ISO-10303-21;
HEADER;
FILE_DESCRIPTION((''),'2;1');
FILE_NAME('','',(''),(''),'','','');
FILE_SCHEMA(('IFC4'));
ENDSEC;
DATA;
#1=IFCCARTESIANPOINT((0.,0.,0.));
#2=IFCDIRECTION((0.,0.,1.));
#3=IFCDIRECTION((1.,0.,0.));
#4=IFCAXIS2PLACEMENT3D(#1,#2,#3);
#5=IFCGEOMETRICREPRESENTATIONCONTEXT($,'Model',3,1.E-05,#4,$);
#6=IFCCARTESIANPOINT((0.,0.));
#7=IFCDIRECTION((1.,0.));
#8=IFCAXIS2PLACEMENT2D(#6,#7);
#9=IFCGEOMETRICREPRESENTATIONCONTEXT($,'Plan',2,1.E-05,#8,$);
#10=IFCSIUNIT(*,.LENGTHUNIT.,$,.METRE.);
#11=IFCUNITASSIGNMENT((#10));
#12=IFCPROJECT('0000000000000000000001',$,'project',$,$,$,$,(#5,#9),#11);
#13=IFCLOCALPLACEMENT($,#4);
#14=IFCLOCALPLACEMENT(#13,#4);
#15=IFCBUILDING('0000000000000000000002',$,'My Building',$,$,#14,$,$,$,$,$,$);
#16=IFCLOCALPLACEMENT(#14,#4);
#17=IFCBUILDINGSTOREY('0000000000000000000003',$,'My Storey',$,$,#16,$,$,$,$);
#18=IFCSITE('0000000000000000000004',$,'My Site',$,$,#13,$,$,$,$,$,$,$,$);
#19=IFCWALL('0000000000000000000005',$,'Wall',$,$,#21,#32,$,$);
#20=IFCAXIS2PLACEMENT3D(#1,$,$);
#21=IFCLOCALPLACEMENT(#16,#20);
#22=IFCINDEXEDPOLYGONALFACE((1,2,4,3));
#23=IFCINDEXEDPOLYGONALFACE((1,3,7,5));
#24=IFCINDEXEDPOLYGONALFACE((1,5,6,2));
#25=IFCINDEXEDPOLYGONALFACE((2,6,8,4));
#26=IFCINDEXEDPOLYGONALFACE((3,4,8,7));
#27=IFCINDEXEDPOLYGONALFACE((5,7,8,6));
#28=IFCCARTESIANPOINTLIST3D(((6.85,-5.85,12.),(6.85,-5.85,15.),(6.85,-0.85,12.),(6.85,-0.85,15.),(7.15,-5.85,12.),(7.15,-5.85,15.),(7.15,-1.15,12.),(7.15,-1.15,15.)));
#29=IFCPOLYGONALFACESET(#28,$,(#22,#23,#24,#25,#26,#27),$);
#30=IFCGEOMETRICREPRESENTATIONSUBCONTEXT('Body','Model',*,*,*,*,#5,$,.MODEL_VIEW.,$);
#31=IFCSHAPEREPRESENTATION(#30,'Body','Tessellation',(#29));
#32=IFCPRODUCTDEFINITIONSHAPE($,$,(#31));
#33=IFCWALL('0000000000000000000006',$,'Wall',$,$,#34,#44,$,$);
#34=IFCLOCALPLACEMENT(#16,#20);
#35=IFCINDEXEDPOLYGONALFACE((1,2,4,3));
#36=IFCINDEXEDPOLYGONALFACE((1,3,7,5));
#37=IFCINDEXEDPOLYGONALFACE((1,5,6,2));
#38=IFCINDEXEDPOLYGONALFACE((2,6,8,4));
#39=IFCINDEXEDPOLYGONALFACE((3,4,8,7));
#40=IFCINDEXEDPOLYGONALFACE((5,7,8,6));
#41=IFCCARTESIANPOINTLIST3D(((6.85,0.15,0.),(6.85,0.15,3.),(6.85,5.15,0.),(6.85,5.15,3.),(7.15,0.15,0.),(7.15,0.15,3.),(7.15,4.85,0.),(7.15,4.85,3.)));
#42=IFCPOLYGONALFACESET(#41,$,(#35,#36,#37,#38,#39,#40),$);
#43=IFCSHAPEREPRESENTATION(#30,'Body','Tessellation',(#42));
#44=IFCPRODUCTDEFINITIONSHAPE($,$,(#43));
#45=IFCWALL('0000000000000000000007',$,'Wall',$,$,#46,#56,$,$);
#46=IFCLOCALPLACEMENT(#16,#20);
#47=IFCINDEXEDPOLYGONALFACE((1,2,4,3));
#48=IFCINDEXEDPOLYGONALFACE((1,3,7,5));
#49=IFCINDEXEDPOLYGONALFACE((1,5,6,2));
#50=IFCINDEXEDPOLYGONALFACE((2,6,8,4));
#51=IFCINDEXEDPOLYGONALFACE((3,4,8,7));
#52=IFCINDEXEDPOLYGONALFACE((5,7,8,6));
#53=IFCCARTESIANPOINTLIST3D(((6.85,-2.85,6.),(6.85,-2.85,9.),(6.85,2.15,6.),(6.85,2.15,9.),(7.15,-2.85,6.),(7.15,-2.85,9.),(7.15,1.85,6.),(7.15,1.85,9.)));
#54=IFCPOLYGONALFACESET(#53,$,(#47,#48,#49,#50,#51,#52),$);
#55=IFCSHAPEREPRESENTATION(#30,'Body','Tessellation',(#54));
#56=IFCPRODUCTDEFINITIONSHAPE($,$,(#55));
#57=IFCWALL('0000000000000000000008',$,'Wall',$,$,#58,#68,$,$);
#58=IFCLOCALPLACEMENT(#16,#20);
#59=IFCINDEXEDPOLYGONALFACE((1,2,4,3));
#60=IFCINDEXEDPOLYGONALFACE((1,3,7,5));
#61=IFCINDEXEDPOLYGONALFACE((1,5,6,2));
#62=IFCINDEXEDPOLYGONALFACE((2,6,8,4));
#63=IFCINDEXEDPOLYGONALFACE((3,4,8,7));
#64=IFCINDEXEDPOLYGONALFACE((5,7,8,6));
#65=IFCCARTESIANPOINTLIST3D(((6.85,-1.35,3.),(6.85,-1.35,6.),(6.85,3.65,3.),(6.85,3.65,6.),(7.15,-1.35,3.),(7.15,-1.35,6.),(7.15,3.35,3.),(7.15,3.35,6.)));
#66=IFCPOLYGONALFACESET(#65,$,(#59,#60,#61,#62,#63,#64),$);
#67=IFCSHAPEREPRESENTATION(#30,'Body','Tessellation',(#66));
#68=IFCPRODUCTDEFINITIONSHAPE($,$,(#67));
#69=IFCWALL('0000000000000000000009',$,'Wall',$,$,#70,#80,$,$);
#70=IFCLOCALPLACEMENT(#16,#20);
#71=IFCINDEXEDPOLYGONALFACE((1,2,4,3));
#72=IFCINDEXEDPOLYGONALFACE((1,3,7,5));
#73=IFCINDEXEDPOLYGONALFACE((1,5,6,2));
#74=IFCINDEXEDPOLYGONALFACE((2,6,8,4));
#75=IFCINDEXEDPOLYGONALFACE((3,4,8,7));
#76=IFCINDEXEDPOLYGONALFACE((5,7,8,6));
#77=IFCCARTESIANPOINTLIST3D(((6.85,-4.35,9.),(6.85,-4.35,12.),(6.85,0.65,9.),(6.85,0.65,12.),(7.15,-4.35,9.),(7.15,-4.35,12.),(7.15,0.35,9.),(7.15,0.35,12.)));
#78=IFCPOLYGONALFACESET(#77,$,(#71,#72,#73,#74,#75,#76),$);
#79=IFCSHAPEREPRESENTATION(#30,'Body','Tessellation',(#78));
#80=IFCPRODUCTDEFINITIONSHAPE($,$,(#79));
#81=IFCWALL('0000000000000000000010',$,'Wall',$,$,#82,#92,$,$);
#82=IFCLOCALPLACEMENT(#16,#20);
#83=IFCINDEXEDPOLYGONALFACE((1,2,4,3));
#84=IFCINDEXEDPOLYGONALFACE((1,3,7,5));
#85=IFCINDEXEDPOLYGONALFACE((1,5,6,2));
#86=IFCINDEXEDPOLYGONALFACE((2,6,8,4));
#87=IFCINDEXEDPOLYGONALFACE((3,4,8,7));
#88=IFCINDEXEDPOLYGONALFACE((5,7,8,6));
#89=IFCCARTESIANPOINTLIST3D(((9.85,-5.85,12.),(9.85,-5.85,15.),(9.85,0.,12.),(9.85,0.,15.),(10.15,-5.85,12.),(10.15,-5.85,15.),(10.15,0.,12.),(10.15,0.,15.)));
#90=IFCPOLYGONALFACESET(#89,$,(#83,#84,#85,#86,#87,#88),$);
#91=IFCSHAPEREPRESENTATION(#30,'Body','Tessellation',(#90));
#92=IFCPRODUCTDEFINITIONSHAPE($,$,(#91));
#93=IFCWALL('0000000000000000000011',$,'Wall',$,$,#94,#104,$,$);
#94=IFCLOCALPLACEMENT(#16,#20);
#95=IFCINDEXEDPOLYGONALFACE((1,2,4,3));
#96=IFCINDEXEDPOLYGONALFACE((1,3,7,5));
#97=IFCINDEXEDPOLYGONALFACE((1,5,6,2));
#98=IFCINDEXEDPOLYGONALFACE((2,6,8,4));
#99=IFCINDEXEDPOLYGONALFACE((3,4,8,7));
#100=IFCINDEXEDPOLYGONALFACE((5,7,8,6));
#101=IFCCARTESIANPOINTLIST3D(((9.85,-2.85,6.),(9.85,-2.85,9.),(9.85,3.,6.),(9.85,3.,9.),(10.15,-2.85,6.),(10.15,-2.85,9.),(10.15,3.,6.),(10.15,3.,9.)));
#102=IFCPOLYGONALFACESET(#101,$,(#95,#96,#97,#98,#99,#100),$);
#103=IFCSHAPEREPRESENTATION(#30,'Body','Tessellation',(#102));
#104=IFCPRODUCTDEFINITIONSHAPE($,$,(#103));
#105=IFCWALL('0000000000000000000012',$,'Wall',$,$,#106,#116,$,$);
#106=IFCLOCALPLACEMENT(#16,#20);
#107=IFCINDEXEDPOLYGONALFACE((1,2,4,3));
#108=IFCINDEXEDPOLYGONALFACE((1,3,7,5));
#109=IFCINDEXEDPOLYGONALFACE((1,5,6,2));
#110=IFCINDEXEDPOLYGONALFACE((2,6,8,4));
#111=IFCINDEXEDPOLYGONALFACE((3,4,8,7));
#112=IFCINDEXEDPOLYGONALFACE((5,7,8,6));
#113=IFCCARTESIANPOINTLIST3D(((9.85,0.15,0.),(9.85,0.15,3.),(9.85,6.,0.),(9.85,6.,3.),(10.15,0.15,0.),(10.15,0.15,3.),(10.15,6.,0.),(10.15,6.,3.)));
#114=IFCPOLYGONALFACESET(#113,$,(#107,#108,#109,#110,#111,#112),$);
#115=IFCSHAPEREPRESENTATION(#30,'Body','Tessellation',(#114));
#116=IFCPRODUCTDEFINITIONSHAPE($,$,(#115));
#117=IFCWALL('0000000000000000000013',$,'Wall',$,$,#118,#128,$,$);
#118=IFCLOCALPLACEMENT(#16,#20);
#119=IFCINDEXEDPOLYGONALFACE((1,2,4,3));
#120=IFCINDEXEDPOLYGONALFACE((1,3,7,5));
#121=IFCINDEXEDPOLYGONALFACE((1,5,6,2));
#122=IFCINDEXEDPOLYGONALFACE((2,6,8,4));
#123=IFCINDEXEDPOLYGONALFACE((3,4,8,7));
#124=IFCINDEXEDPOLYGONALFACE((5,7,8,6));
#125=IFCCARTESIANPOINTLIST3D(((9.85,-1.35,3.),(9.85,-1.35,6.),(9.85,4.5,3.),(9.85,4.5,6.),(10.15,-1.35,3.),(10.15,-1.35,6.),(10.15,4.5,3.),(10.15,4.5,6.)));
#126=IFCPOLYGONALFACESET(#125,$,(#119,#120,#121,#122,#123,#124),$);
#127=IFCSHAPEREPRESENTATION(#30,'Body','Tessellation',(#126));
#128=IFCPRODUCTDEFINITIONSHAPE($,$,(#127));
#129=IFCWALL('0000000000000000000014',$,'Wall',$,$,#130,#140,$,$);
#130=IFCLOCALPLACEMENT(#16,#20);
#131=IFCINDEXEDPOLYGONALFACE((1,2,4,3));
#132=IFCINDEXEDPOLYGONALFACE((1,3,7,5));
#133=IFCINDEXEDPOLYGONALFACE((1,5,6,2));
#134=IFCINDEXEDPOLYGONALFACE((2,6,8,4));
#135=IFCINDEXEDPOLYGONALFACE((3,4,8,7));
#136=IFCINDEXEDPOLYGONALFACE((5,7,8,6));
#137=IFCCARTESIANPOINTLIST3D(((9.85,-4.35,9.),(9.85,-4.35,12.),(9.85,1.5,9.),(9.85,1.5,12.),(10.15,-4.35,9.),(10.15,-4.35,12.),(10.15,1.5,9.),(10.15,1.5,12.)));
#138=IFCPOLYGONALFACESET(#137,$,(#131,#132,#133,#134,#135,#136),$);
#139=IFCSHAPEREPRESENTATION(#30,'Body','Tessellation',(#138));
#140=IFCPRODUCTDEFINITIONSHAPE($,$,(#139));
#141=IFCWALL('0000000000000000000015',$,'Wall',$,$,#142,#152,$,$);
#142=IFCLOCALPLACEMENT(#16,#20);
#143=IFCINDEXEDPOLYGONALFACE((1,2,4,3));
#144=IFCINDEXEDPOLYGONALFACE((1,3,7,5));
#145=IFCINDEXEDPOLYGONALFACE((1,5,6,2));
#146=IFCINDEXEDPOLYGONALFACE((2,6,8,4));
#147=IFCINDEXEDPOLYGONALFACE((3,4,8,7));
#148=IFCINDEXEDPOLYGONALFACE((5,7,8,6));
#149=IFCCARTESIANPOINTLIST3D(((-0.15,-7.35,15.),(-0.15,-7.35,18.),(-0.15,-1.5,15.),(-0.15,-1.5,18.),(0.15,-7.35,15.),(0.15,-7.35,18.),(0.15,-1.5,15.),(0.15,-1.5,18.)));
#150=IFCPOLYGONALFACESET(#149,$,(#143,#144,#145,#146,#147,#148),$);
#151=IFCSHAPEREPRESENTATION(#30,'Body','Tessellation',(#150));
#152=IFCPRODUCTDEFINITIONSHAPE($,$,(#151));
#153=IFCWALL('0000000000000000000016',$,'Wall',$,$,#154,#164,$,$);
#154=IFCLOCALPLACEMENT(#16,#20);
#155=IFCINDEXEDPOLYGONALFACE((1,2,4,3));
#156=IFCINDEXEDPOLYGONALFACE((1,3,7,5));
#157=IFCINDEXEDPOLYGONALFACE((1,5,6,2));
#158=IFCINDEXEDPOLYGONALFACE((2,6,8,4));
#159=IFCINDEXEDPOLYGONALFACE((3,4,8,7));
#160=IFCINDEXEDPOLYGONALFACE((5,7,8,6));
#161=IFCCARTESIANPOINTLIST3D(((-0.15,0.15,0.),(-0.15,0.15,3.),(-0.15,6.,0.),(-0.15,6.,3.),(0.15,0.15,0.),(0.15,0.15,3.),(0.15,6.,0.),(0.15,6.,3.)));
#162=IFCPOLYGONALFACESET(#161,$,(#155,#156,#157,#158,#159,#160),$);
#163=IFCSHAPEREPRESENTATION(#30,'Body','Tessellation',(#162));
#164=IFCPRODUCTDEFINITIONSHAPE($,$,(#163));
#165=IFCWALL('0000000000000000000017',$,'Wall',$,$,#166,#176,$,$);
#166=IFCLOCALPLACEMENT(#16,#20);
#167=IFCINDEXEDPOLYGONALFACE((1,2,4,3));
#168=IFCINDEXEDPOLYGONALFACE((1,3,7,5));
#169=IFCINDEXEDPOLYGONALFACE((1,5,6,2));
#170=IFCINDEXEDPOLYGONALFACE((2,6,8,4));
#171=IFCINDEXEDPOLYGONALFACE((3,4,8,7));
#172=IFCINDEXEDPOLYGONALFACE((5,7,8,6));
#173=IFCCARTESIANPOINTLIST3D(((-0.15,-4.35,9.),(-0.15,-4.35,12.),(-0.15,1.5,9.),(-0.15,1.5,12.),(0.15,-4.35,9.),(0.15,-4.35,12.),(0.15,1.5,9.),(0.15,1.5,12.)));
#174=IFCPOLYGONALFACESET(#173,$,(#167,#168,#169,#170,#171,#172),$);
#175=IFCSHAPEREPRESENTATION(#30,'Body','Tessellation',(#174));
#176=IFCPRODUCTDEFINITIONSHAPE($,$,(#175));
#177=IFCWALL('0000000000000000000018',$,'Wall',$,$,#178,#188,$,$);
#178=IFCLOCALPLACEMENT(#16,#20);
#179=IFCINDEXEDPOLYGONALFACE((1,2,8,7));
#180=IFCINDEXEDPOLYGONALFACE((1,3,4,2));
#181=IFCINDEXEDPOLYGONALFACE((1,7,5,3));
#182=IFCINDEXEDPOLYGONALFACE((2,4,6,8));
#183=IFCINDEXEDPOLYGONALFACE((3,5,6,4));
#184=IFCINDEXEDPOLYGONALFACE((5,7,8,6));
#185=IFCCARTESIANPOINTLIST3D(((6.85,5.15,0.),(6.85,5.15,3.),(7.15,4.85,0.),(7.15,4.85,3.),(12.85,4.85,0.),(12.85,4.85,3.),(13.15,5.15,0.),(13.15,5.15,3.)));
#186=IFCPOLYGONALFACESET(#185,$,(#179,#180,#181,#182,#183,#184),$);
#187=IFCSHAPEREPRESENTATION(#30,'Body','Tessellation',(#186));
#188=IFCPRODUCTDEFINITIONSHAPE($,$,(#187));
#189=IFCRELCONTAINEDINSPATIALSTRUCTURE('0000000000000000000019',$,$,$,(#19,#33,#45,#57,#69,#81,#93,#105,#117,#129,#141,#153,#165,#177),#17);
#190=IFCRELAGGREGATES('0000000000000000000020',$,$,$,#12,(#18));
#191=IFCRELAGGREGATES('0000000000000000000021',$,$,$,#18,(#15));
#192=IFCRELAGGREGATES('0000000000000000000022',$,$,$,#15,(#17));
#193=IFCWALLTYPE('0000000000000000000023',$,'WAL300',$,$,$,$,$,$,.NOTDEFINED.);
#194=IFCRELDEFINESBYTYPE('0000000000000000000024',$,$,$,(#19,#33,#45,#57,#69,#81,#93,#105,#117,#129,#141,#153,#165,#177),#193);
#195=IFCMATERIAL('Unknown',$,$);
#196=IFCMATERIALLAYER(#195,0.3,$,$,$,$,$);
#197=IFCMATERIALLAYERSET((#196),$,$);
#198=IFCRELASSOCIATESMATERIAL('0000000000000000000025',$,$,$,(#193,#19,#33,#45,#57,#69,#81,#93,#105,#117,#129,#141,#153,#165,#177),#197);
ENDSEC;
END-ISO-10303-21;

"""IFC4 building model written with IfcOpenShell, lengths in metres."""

from ifc_helpers import new_model, si_unit, frame, origin_with_axes, origin_2d_with_axis, place, context, subcontext, project, spatial, line, indexed_curve, outline, extrude, material, layer, layer_set, layer_usage, type_object, element, save


model = new_model("IFC4")

# Units and contexts
model_context = context("Model", 3, precision=1e-05, world=origin_with_axes())
plan_context = context("Plan", 2, precision=1e-05, world=origin_2d_with_axis())
body_context = subcontext(model_context, "Body", "Model", "MODEL_VIEW")
ifc_project = project(units=[si_unit("LENGTHUNIT", "METRE")], contexts=[model_context, plan_context])

# Site, building, storey
site_placement = place(None, origin_with_axes())
site = spatial("IfcSite", under=ifc_project, at=site_placement, Name="My Site")
building_placement = place(site_placement, origin_with_axes())
building = spatial("IfcBuilding", under=site, at=building_placement, Name="My Building")
storey_placement = place(building_placement, origin_with_axes())
storey = spatial("IfcBuildingStorey", under=building, at=storey_placement, Name="My Storey")

# Walls
ifc_material = material(Name="Unknown")
ifc_layer = layer(ifc_material, 0.3)
ifc_layer_set = layer_set([ifc_layer])
ifc_layer_usage_1 = layer_usage(ifc_layer_set, "AXIS2", "POSITIVE", -0.15)
wall_type = type_object("IfcWallType", Name="WAL300", PredefinedType="NOTDEFINED", material=ifc_layer_set)
wall_1_placement = place(storey_placement, frame((7.0, -1.0, 12.0), z_axis=(0.0, 0.0, 1.0), x_axis=(0.0, -1.0, 0.0)))
element("IfcWall", 1, at=wall_1_placement, inside=storey, type_object=wall_type, material=ifc_layer_usage_1, Name="Wall", context=body_context, shape_type="SweptSolid", body=[
    extrude(outline(indexed_curve([(-0.15, -0.15), (0.15, 0.15), (4.85, 0.15), (4.85, -0.15)], segments=[line(1, 2, 3, 4, 1)])), origin_with_axes(), (0.0, 0.0, 1.0), 3.0),
])
ifc_layer_usage_2 = layer_usage(ifc_layer_set, "AXIS2", "POSITIVE", -0.15)
wall_2_placement = place(storey_placement, frame((7.0, 5.0, 0.0), z_axis=(0.0, 0.0, 1.0), x_axis=(0.0, -1.0, 0.0)))
element("IfcWall", 2, at=wall_2_placement, inside=storey, type_object=wall_type, material=ifc_layer_usage_2, Name="Wall", context=body_context, shape_type="SweptSolid", body=[
    extrude(outline(indexed_curve([(-0.15, -0.15), (0.15, 0.15), (4.85, 0.15), (4.85, -0.15)], segments=[line(1, 2, 3, 4, 1)])), origin_with_axes(), (0.0, 0.0, 1.0), 3.0),
])
ifc_layer_usage_3 = layer_usage(ifc_layer_set, "AXIS2", "POSITIVE", -0.15)
wall_3_placement = place(storey_placement, frame((7.0, 2.0, 6.0), z_axis=(0.0, 0.0, 1.0), x_axis=(0.0, -1.0, 0.0)))
element("IfcWall", 3, at=wall_3_placement, inside=storey, type_object=wall_type, material=ifc_layer_usage_3, Name="Wall", context=body_context, shape_type="SweptSolid", body=[
    extrude(outline(indexed_curve([(-0.15, -0.15), (0.15, 0.15), (4.85, 0.15), (4.85, -0.15)], segments=[line(1, 2, 3, 4, 1)])), origin_with_axes(), (0.0, 0.0, 1.0), 3.0),
])
ifc_layer_usage_4 = layer_usage(ifc_layer_set, "AXIS2", "POSITIVE", -0.15)
wall_4_placement = place(storey_placement, frame((7.0, 3.5, 3.0), z_axis=(0.0, 0.0, 1.0), x_axis=(0.0, -1.0, 0.0)))
element("IfcWall", 4, at=wall_4_placement, inside=storey, type_object=wall_type, material=ifc_layer_usage_4, Name="Wall", context=body_context, shape_type="SweptSolid", body=[
    extrude(outline(indexed_curve([(-0.15, -0.15), (0.15, 0.15), (4.85, 0.15), (4.85, -0.15)], segments=[line(1, 2, 3, 4, 1)])), origin_with_axes(), (0.0, 0.0, 1.0), 3.0),
])
ifc_layer_usage_5 = layer_usage(ifc_layer_set, "AXIS2", "POSITIVE", -0.15)
wall_5_placement = place(storey_placement, frame((7.0, 0.5, 9.0), z_axis=(0.0, 0.0, 1.0), x_axis=(0.0, -1.0, 0.0)))
element("IfcWall", 5, at=wall_5_placement, inside=storey, type_object=wall_type, material=ifc_layer_usage_5, Name="Wall", context=body_context, shape_type="SweptSolid", body=[
    extrude(outline(indexed_curve([(-0.15, -0.15), (0.15, 0.15), (4.85, 0.15), (4.85, -0.15)], segments=[line(1, 2, 3, 4, 1)])), origin_with_axes(), (0.0, 0.0, 1.0), 3.0),
])
ifc_layer_usage_6 = layer_usage(ifc_layer_set, "AXIS2", "POSITIVE", -0.15)
wall_6_placement = place(storey_placement, frame((10.0, 0.0, 12.0), z_axis=(0.0, 0.0, 1.0), x_axis=(0.0, -1.0, 0.0)))
element("IfcWall", 6, at=wall_6_placement, inside=storey, type_object=wall_type, material=ifc_layer_usage_6, Name="Wall", context=body_context, shape_type="SweptSolid", body=[
    extrude(outline(indexed_curve([(0.0, -0.15), (0.0, 0.15), (5.85, 0.15), (5.85, -0.15)], segments=[line(1, 2, 3, 4, 1)])), origin_with_axes(), (0.0, 0.0, 1.0), 3.0),
])
ifc_layer_usage_7 = layer_usage(ifc_layer_set, "AXIS2", "POSITIVE", -0.15)
wall_7_placement = place(storey_placement, frame((10.0, 3.0, 6.0), z_axis=(0.0, 0.0, 1.0), x_axis=(0.0, -1.0, 0.0)))
element("IfcWall", 7, at=wall_7_placement, inside=storey, type_object=wall_type, material=ifc_layer_usage_7, Name="Wall", context=body_context, shape_type="SweptSolid", body=[
    extrude(outline(indexed_curve([(0.0, -0.15), (0.0, 0.15), (5.85, 0.15), (5.85, -0.15)], segments=[line(1, 2, 3, 4, 1)])), origin_with_axes(), (0.0, 0.0, 1.0), 3.0),
])
ifc_layer_usage_8 = layer_usage(ifc_layer_set, "AXIS2", "POSITIVE", -0.15)
wall_8_placement = place(storey_placement, frame((10.0, 6.0, 0.0), z_axis=(0.0, 0.0, 1.0), x_axis=(0.0, -1.0, 0.0)))
element("IfcWall", 8, at=wall_8_placement, inside=storey, type_object=wall_type, material=ifc_layer_usage_8, Name="Wall", context=body_context, shape_type="SweptSolid", body=[
    extrude(outline(indexed_curve([(0.0, -0.15), (0.0, 0.15), (5.85, 0.15), (5.85, -0.15)], segments=[line(1, 2, 3, 4, 1)])), origin_with_axes(), (0.0, 0.0, 1.0), 3.0),
])
ifc_layer_usage_9 = layer_usage(ifc_layer_set, "AXIS2", "POSITIVE", -0.15)
wall_9_placement = place(storey_placement, frame((10.0, 4.5, 3.0), z_axis=(0.0, 0.0, 1.0), x_axis=(0.0, -1.0, 0.0)))
element("IfcWall", 9, at=wall_9_placement, inside=storey, type_object=wall_type, material=ifc_layer_usage_9, Name="Wall", context=body_context, shape_type="SweptSolid", body=[
    extrude(outline(indexed_curve([(0.0, -0.15), (0.0, 0.15), (5.85, 0.15), (5.85, -0.15)], segments=[line(1, 2, 3, 4, 1)])), origin_with_axes(), (0.0, 0.0, 1.0), 3.0),
])
ifc_layer_usage_10 = layer_usage(ifc_layer_set, "AXIS2", "POSITIVE", -0.15)
wall_10_placement = place(storey_placement, frame((10.0, 1.5, 9.0), z_axis=(0.0, 0.0, 1.0), x_axis=(0.0, -1.0, 0.0)))
element("IfcWall", 10, at=wall_10_placement, inside=storey, type_object=wall_type, material=ifc_layer_usage_10, Name="Wall", context=body_context, shape_type="SweptSolid", body=[
    extrude(outline(indexed_curve([(0.0, -0.15), (0.0, 0.15), (5.85, 0.15), (5.85, -0.15)], segments=[line(1, 2, 3, 4, 1)])), origin_with_axes(), (0.0, 0.0, 1.0), 3.0),
])
ifc_layer_usage_11 = layer_usage(ifc_layer_set, "AXIS2", "POSITIVE", -0.15)
wall_11_placement = place(storey_placement, frame((0.0, -7.5, 15.0), z_axis=(0.0, 0.0, 1.0), x_axis=(0.0, 1.0, 0.0)))
element("IfcWall", 11, at=wall_11_placement, inside=storey, type_object=wall_type, material=ifc_layer_usage_11, Name="Wall", context=body_context, shape_type="SweptSolid", body=[
    extrude(outline(indexed_curve([(0.15, -0.15), (0.15, 0.15), (6.0, 0.15), (6.0, -0.15)], segments=[line(1, 2, 3, 4, 1)])), origin_with_axes(), (0.0, 0.0, 1.0), 3.0),
])
ifc_layer_usage_12 = layer_usage(ifc_layer_set, "AXIS2", "POSITIVE", -0.15)
wall_12_placement = place(storey_placement, frame((0.0, 0.0, 0.0), z_axis=(0.0, 0.0, 1.0), x_axis=(0.0, 1.0, 0.0)))
element("IfcWall", 12, at=wall_12_placement, inside=storey, type_object=wall_type, material=ifc_layer_usage_12, Name="Wall", context=body_context, shape_type="SweptSolid", body=[
    extrude(outline(indexed_curve([(0.15, -0.15), (0.15, 0.15), (6.0, 0.15), (6.0, -0.15)], segments=[line(1, 2, 3, 4, 1)])), origin_with_axes(), (0.0, 0.0, 1.0), 3.0),
])
ifc_layer_usage_13 = layer_usage(ifc_layer_set, "AXIS2", "POSITIVE", -0.15)
wall_13_placement = place(storey_placement, frame((0.0, -4.5, 9.0), z_axis=(0.0, 0.0, 1.0), x_axis=(0.0, 1.0, 0.0)))
element("IfcWall", 13, at=wall_13_placement, inside=storey, type_object=wall_type, material=ifc_layer_usage_13, Name="Wall", context=body_context, shape_type="SweptSolid", body=[
    extrude(outline(indexed_curve([(0.15, -0.15), (0.15, 0.15), (6.0, 0.15), (6.0, -0.15)], segments=[line(1, 2, 3, 4, 1)])), origin_with_axes(), (0.0, 0.0, 1.0), 3.0),
])
ifc_layer_usage_14 = layer_usage(ifc_layer_set, "AXIS2", "POSITIVE", -0.15)
wall_14_placement = place(storey_placement, frame((7.0, 5.0, 0.0), z_axis=(0.0, 0.0, 1.0), x_axis=(1.0, 0.0, 0.0)))
element("IfcWall", 14, at=wall_14_placement, inside=storey, type_object=wall_type, material=ifc_layer_usage_14, Name="Wall", context=body_context, shape_type="SweptSolid", body=[
    extrude(outline(indexed_curve([(0.15, -0.15), (-0.15, 0.15), (6.15, 0.15), (5.85, -0.15)], segments=[line(1, 2, 3, 4, 1)])), origin_with_axes(), (0.0, 0.0, 1.0), 3.0),
])

save(model, "model.ifc")
